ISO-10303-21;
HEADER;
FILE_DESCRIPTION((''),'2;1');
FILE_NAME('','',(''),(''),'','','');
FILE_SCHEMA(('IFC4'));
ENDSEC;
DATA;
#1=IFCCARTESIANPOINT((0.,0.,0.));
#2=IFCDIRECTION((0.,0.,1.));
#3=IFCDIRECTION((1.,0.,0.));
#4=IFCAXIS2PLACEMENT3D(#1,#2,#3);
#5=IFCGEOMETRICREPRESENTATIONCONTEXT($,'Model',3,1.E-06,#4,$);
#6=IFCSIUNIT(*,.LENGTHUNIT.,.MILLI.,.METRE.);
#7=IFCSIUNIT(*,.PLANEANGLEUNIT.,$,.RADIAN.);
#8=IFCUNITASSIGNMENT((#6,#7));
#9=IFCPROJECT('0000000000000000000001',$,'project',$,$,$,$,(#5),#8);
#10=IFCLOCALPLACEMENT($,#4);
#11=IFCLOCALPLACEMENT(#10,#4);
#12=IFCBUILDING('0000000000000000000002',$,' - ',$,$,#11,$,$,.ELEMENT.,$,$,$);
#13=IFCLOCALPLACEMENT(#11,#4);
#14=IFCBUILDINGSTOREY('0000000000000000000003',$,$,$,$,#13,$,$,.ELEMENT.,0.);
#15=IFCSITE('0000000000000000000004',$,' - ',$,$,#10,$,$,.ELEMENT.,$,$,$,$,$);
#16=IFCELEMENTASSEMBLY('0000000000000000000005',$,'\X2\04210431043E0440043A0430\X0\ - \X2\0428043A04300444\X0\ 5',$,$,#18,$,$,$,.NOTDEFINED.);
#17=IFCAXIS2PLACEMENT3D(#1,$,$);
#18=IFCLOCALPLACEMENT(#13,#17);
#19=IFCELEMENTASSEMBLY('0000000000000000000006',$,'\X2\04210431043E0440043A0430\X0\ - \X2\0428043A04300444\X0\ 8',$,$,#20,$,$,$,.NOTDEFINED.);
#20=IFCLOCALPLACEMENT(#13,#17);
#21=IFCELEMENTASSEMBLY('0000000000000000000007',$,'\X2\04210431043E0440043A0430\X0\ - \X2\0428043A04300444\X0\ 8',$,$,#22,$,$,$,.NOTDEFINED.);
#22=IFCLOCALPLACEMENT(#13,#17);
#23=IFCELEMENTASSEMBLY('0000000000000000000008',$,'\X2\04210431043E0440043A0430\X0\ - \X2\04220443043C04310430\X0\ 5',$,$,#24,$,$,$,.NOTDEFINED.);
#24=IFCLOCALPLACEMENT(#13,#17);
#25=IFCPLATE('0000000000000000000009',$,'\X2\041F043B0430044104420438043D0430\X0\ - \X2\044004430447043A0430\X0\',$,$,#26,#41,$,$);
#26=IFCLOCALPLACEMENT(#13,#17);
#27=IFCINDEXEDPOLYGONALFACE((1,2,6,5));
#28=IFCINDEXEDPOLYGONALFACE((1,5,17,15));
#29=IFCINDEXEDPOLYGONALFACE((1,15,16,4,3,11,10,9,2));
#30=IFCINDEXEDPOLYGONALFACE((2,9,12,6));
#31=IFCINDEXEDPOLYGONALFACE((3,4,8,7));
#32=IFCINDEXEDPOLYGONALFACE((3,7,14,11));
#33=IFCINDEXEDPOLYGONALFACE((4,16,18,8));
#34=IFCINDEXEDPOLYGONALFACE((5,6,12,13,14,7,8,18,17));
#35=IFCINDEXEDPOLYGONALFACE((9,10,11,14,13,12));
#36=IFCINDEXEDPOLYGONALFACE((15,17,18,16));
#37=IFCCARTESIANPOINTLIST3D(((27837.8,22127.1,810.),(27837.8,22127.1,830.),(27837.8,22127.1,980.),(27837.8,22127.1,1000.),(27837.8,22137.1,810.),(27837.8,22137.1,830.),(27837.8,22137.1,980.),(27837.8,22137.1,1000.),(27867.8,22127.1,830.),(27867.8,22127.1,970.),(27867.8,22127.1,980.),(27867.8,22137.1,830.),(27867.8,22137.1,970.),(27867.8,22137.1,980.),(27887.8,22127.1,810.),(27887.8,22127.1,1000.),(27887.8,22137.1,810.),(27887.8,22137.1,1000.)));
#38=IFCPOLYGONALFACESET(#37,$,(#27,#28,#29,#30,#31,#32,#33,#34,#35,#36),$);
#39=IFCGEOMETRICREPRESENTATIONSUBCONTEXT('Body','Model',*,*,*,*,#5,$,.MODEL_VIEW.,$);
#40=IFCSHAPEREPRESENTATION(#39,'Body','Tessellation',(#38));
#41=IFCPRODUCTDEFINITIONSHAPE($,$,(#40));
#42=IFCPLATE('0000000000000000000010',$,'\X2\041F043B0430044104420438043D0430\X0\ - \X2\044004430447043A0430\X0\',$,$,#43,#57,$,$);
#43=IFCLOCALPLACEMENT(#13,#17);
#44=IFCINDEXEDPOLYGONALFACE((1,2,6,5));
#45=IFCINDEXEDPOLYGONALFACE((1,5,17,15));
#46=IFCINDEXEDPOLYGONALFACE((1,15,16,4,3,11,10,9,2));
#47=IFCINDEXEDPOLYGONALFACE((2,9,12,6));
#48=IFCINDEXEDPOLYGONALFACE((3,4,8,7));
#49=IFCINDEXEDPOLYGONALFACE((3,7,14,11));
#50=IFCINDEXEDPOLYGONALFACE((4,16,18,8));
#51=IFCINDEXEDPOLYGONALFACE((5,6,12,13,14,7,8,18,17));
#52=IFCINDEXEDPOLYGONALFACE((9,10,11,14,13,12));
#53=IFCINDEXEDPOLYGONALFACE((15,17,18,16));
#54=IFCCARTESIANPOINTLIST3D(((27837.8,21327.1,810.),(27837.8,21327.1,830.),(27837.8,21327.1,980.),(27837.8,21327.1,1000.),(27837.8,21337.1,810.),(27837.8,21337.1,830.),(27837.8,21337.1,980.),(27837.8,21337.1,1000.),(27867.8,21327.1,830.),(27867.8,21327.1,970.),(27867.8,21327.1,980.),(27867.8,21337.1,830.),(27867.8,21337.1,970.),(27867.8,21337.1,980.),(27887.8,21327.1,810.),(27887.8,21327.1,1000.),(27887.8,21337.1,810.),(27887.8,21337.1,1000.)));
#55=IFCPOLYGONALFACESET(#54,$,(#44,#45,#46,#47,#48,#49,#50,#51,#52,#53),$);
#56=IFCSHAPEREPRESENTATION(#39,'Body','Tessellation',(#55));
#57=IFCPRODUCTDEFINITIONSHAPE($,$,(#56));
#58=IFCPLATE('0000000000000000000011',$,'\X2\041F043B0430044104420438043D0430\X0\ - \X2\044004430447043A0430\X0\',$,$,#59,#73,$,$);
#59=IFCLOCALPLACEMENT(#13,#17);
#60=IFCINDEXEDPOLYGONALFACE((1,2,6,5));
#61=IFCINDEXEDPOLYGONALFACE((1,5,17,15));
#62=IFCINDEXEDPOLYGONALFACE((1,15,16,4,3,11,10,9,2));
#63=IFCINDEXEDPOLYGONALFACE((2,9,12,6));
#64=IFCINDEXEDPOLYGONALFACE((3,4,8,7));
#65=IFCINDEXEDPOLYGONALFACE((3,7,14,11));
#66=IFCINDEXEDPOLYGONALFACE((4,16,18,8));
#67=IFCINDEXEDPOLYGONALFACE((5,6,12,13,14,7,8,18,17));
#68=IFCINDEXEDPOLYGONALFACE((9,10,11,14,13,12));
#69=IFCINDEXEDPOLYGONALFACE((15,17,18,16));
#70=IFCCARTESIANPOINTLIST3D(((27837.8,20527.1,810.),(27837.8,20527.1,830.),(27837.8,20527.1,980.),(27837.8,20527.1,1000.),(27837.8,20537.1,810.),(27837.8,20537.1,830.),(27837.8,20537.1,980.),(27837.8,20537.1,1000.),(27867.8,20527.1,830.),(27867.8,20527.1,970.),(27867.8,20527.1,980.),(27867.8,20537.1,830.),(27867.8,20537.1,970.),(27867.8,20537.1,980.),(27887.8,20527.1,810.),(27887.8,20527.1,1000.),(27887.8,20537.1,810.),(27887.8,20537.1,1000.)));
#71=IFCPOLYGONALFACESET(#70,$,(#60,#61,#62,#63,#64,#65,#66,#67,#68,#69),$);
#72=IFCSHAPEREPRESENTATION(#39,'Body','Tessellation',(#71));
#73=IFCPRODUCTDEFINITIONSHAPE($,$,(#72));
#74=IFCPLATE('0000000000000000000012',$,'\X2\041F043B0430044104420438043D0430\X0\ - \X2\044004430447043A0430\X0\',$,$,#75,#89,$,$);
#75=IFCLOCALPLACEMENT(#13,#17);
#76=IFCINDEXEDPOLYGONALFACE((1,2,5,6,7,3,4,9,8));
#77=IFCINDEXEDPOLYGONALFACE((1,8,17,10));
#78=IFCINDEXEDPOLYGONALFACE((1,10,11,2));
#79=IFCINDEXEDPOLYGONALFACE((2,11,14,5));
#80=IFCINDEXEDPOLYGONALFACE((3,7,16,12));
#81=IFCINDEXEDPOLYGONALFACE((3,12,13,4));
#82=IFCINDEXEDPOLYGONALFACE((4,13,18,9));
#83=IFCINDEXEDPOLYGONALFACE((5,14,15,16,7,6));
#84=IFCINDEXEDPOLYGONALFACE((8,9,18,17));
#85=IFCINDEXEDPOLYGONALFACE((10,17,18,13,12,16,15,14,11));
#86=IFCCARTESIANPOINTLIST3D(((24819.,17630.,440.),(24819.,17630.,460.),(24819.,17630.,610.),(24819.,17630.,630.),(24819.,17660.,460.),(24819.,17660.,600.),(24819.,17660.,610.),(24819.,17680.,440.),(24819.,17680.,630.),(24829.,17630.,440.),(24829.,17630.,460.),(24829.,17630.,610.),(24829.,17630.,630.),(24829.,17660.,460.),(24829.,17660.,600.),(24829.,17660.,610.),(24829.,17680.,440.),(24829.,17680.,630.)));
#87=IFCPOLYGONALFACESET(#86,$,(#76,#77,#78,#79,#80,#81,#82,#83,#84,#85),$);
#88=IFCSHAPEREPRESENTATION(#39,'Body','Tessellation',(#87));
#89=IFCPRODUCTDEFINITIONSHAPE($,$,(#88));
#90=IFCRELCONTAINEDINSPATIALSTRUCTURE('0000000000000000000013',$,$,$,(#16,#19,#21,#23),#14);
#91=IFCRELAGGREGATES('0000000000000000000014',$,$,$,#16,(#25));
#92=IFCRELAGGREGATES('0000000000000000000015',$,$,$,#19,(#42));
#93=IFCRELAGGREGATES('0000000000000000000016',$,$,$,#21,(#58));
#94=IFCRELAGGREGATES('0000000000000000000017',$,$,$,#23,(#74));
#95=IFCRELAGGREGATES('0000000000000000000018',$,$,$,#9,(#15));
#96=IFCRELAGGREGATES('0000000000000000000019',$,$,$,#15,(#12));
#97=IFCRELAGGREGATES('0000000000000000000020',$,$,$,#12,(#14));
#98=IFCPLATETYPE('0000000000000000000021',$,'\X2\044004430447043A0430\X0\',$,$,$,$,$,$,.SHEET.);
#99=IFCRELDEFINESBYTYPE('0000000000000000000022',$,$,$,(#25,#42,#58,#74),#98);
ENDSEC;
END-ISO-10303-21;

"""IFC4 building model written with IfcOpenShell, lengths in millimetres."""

from ifc_helpers import new_model, si_unit, frame, origin_with_axes, place, context, subcontext, project, spatial, line, indexed_curve, outline, extrude, source, transform, mapped, type_object, element, aggregate, save


model = new_model("IFC4")

# Units and contexts
model_context = context("Model", 3, precision=1e-06, world=origin_with_axes())
body_context = subcontext(model_context, "Body", "Model", "MODEL_VIEW")
ifc_project = project(units=[si_unit("LENGTHUNIT", "METRE", prefix="MILLI"), si_unit("PLANEANGLEUNIT", "RADIAN")], contexts=[model_context])

# Site, building, storey
site_placement = place(None, origin_with_axes())
site = spatial("IfcSite", under=ifc_project, at=site_placement, Name=" - ", CompositionType="ELEMENT")
building_placement = place(site_placement, origin_with_axes())
building = spatial("IfcBuilding", under=site, at=building_placement, Name=" - ", CompositionType="ELEMENT")
storey_placement = place(building_placement, origin_with_axes())
storey = spatial("IfcBuildingStorey", under=building, at=storey_placement, CompositionType="ELEMENT", Elevation=0.0)

# Shared definitions
plate_type = type_object("IfcPlateType", Name="ручка", PredefinedType="SHEET")

# Element assemblies
assembly_1_placement = place(storey_placement, frame((27837.8, 21767.1, 0.0), z_axis=(0.0, 0.0, 1.0), x_axis=(0.0, 1.0, 0.0)))
assembly_1 = element("IfcElementAssembly", 1, at=assembly_1_placement, inside=storey, Name="Сборка - Шкаф 5", PredefinedType="NOTDEFINED")
assembly_2_placement = place(storey_placement, frame((27837.8, 20967.1, 0.0), z_axis=(0.0, 0.0, 1.0), x_axis=(0.0, 1.0, 0.0)))
assembly_2 = element("IfcElementAssembly", 2, at=assembly_2_placement, inside=storey, Name="Сборка - Шкаф 8", PredefinedType="NOTDEFINED")
assembly_3_placement = place(storey_placement, frame((27837.8, 20167.1, 0.0), z_axis=(0.0, 0.0, 1.0), x_axis=(0.0, 1.0, 0.0)))
assembly_3 = element("IfcElementAssembly", 3, at=assembly_3_placement, inside=storey, Name="Сборка - Шкаф 8", PredefinedType="NOTDEFINED")
assembly_4_placement = place(storey_placement, frame((25449.0, 17430.0, 0.0), z_axis=(0.0, 0.0, 1.0), x_axis=(-1.0, 0.0, 0.0)))
assembly_4 = element("IfcElementAssembly", 4, at=assembly_4_placement, inside=storey, Name="Сборка - Тумба 5", PredefinedType="NOTDEFINED")

# Plates
shared_shape_1 = source(origin_with_axes(), body_context, "Body", "SweptSolid", [
    extrude(outline(indexed_curve([(-95.0, -25.0), (-75.0, -25.0), (-75.0, 5.0), (-65.0, 5.0), (75.0, 5.0), (75.0, -25.0), (95.0, -25.0), (95.0, 25.0), (-95.0, 25.0)], segments=[line(1, 2), line(2, 3), line(3, 4), line(4, 5), line(5, 6), line(6, 7), line(7, 8), line(8, 9), line(9, 1)])), origin_with_axes(), (0.0, 0.0, 1.0), 10.0),
])
plate_1_placement = place(assembly_1_placement, frame((370.0, -25.0, 905.0), z_axis=(-1.0, 0.0, 0.0), x_axis=(0.0, 0.0, -1.0)))
plate_1 = element("IfcPlate", 5, at=plate_1_placement, type_object=plate_type, Name="Пластина - ручка", context=body_context, shape_type="MappedRepresentation", body=[
    mapped(shared_shape_1, transform((0.0, 0.0, 0.0), x_axis=(1.0, 0.0, 0.0), y_axis=(0.0, 1.0, 0.0), z_axis=(0.0, 0.0, 1.0), scale=1.0)),
])
aggregate(assembly_1, [plate_1])
plate_2_placement = place(assembly_2_placement, frame((370.0, -25.0, 905.0), z_axis=(-1.0, 0.0, 0.0), x_axis=(0.0, 0.0, -1.0)))
plate_2 = element("IfcPlate", 6, at=plate_2_placement, type_object=plate_type, Name="Пластина - ручка", context=body_context, shape_type="MappedRepresentation", body=[
    mapped(shared_shape_1, transform((0.0, 0.0, 0.0), x_axis=(1.0, 0.0, 0.0), y_axis=(0.0, 1.0, 0.0), z_axis=(0.0, 0.0, 1.0), scale=1.0)),
])
aggregate(assembly_2, [plate_2])
plate_3_placement = place(assembly_3_placement, frame((370.0, -25.0, 905.0), z_axis=(-1.0, 0.0, 0.0), x_axis=(0.0, 0.0, -1.0)))
plate_3 = element("IfcPlate", 7, at=plate_3_placement, type_object=plate_type, Name="Пластина - ручка", context=body_context, shape_type="MappedRepresentation", body=[
    mapped(shared_shape_1, transform((0.0, 0.0, 0.0), x_axis=(1.0, 0.0, 0.0), y_axis=(0.0, 1.0, 0.0), z_axis=(0.0, 0.0, 1.0), scale=1.0)),
])
aggregate(assembly_3, [plate_3])
plate_4_placement = place(assembly_4_placement, frame((630.0, -225.0, 535.0), z_axis=(-1.0, 0.0, 0.0), x_axis=(0.0, 0.0, -1.0)))
plate_4 = element("IfcPlate", 8, at=plate_4_placement, type_object=plate_type, Name="Пластина - ручка", context=body_context, shape_type="MappedRepresentation", body=[
    mapped(shared_shape_1, transform((0.0, 0.0, 0.0), x_axis=(1.0, 0.0, 0.0), y_axis=(0.0, 1.0, 0.0), z_axis=(0.0, 0.0, 1.0), scale=1.0)),
])
aggregate(assembly_4, [plate_4])

save(model, "model.ifc")
